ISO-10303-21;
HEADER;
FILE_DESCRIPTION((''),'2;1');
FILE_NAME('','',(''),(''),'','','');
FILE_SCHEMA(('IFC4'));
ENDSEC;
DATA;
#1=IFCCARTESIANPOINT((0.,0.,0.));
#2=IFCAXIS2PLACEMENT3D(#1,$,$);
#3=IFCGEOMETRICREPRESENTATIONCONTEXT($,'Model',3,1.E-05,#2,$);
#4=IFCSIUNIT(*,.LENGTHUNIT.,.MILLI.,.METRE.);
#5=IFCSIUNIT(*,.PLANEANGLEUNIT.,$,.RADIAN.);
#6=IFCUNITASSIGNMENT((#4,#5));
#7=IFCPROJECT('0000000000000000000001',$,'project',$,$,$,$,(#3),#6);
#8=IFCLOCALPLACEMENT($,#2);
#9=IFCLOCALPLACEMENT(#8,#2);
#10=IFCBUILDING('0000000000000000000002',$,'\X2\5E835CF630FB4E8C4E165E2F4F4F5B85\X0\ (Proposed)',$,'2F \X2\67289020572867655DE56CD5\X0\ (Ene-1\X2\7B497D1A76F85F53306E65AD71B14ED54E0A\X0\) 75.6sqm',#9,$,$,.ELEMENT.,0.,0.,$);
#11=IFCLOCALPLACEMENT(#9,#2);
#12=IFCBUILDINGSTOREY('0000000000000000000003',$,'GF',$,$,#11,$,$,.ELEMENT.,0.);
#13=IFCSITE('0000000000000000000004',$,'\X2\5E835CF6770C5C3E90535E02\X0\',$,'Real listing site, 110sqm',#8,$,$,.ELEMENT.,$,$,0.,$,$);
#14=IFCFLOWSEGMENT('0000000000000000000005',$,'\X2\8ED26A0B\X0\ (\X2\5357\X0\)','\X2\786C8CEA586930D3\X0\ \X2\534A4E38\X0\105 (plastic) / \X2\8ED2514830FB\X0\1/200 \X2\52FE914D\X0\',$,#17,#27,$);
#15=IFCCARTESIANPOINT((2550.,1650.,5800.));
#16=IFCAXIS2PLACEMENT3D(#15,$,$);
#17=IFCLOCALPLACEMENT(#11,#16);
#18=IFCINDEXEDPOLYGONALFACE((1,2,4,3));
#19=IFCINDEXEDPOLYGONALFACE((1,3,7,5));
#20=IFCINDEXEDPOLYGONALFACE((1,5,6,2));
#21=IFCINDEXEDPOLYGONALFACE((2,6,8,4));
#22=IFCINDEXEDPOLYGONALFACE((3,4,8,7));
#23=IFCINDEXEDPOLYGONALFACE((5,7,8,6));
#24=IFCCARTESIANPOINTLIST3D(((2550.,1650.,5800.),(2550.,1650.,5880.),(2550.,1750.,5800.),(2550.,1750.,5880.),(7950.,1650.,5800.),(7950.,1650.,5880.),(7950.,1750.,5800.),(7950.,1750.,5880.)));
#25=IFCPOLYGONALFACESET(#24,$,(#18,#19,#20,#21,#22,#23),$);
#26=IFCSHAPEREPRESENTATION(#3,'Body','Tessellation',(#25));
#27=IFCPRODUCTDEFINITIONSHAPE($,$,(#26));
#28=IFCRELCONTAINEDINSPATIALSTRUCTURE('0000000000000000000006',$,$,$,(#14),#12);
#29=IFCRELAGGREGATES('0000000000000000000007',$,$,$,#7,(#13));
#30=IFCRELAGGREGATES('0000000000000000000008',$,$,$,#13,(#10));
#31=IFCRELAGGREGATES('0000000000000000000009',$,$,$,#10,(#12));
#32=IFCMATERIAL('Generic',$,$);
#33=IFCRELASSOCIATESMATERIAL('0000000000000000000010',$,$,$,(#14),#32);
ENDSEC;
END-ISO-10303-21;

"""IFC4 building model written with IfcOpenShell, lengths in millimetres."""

from ifc_helpers import new_model, si_unit, frame, frame_2d, origin, place, context, project, spatial, rectangle, extrude, material, element, save


model = new_model("IFC4")

# Units and contexts
model_context = context("Model", 3, precision=1e-05, world=origin())
ifc_project = project(units=[si_unit("LENGTHUNIT", "METRE", prefix="MILLI"), si_unit("PLANEANGLEUNIT", "RADIAN")], contexts=[model_context])

# Site, building, storey
site_placement = place(None, origin())
site = spatial("IfcSite", under=ifc_project, at=site_placement, Name="広島県尾道市", ObjectType="Real listing site, 110sqm", CompositionType="ELEMENT", RefElevation=0.0)
building_placement = place(site_placement, origin())
building = spatial("IfcBuilding", under=site, at=building_placement, Name="広島・二世帯住宅 (Proposed)", ObjectType="2F 木造在来工法 (Ene-1等級相当の断熱仕上) 75.6sqm", CompositionType="ELEMENT", ElevationOfRefHeight=0.0, ElevationOfTerrain=0.0)
storey_placement = place(building_placement, origin())
storey = spatial("IfcBuildingStorey", under=building, at=storey_placement, Name="GF", CompositionType="ELEMENT", Elevation=0.0)

# Flow segment
ifc_material_1 = material(Name="Generic")
flow_segment_placement = place(storey_placement, frame((2550.0, 1650.0, 5800.0)))
element("IfcFlowSegment", 1, at=flow_segment_placement, inside=storey, material=ifc_material_1, Name="軒樋 (南)", Description="硬質塩ビ 半丸105 (plastic) / 軒先・1/200 勾配", context=model_context, shape_type="SweptSolid", body=[
    extrude(rectangle(XDim=5400.0, YDim=100.0, at=frame_2d((2700.0, 50.0))), frame((2550.0, 1650.0, 5800.0)), (0.0, 0.0, 1.0), 80.0),
])

save(model, "model.ifc")
